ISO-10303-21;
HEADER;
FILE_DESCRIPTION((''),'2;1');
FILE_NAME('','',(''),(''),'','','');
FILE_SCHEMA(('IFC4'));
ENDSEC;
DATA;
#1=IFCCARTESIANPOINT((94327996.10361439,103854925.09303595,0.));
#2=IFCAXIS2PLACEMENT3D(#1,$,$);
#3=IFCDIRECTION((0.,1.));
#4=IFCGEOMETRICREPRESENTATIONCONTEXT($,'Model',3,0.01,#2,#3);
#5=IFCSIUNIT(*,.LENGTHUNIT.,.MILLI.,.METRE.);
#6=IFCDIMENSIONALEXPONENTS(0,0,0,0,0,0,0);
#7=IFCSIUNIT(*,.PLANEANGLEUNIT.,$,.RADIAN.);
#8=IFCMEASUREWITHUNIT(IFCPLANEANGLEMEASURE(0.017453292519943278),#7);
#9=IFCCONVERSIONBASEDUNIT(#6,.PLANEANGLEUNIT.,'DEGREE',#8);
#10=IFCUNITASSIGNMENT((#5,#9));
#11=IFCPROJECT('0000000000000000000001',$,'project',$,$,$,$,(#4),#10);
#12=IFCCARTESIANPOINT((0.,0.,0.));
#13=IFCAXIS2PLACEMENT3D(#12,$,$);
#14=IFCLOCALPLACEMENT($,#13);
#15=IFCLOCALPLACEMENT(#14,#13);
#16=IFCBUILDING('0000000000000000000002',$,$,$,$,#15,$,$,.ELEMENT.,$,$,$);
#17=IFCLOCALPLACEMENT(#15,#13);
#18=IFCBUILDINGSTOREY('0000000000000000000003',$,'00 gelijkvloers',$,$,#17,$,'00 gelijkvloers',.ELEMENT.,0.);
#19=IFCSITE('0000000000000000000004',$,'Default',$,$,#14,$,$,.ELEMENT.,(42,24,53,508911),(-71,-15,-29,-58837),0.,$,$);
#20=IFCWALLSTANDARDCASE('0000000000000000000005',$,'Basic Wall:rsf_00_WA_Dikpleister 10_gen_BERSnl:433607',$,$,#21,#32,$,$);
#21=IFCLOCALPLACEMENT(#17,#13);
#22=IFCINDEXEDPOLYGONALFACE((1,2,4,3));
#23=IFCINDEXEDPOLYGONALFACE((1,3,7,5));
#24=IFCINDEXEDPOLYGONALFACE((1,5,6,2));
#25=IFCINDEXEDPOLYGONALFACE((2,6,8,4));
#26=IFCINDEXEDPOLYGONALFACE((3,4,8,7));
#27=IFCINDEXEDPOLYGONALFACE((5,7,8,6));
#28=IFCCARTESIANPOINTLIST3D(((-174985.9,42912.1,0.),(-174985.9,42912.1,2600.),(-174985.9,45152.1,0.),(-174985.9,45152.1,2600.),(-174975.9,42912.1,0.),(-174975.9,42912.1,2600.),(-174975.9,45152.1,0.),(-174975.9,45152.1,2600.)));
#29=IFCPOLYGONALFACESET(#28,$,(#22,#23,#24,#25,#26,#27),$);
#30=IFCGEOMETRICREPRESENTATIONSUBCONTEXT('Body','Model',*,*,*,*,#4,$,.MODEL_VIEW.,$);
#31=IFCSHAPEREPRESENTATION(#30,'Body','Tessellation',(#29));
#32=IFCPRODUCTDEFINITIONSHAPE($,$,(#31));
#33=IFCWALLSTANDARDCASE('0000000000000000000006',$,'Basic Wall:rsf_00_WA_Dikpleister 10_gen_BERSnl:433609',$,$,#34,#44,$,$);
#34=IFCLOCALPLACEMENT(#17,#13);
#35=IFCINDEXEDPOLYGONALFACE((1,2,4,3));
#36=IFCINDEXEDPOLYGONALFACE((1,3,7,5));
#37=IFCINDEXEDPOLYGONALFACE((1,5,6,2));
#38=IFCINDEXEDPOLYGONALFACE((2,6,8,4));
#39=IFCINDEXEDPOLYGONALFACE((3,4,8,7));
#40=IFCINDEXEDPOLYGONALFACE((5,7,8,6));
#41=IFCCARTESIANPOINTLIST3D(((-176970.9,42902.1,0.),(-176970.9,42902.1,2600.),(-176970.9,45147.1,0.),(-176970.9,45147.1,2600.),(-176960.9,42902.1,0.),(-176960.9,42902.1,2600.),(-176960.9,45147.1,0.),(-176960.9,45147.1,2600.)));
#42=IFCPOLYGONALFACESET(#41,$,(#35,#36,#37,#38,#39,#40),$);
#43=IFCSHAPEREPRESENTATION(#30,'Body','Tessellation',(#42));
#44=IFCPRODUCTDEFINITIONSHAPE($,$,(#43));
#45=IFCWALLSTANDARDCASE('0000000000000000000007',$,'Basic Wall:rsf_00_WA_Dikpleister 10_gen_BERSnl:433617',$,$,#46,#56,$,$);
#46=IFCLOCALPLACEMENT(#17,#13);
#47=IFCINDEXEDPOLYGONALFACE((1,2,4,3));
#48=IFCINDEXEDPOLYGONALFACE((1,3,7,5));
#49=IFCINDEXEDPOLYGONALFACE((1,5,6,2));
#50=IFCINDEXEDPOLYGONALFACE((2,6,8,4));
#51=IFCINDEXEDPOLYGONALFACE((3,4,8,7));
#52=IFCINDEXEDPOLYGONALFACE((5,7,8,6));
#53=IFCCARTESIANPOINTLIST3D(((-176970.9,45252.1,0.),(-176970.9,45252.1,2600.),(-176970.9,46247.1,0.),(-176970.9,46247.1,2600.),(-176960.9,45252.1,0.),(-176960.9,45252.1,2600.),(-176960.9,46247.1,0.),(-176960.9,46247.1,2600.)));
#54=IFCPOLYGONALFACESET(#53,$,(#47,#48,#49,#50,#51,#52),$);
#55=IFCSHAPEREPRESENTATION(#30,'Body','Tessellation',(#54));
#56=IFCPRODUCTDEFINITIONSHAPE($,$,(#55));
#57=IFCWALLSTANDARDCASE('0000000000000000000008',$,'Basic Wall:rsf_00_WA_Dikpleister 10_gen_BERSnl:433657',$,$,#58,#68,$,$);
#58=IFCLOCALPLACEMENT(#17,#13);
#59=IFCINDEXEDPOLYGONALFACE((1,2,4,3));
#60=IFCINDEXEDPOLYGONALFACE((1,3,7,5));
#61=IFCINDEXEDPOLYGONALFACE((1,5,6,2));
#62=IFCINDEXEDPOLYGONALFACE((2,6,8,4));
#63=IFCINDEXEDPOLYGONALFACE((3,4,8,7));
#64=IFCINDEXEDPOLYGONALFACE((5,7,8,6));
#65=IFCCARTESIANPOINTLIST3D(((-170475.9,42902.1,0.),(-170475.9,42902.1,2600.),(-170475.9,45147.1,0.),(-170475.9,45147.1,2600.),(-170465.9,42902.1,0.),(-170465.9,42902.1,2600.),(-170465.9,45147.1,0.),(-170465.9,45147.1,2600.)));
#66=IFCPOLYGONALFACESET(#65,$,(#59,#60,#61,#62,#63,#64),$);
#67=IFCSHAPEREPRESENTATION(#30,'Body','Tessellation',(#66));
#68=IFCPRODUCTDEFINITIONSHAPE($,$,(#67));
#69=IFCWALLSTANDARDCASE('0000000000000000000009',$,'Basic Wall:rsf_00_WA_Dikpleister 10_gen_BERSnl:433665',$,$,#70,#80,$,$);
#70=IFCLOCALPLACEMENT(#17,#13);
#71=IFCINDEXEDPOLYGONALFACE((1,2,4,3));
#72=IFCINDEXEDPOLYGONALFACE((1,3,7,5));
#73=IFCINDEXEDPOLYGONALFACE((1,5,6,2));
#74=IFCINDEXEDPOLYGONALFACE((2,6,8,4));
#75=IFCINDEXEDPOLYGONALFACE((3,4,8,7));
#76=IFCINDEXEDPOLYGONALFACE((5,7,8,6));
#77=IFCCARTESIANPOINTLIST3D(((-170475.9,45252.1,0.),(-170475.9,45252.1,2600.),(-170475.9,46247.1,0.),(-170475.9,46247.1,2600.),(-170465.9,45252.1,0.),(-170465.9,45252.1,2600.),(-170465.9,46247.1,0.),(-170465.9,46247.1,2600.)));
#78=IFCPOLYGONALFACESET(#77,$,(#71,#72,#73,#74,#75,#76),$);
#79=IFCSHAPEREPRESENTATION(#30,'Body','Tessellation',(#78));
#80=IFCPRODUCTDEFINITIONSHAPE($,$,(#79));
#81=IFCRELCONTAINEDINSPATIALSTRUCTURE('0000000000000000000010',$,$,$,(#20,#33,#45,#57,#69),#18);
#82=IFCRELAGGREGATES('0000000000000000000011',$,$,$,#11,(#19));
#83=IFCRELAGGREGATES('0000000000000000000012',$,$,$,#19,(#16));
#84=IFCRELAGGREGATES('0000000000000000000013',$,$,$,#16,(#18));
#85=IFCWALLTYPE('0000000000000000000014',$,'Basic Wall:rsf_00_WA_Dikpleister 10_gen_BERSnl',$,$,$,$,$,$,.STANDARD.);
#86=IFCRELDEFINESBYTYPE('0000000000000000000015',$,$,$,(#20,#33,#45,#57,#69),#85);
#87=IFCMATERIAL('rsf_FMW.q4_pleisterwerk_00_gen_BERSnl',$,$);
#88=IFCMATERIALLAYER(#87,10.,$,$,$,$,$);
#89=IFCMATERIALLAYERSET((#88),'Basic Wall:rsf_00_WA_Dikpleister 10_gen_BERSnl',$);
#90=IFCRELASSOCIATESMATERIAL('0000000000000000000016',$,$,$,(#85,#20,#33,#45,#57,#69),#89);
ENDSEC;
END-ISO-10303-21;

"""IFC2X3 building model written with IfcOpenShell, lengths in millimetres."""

from ifc_helpers import new_model, entity, si_unit, converted_unit, direction, frame, frame_2d, origin, place, context, subcontext, project, spatial, rectangle, extrude, material, layer, layer_set, layer_usage, type_object, element, save


model = new_model("IFC2X3")

# Units and contexts
model_context = context("Model", 3, precision=0.01, world=frame((94327996.10361439, 103854925.09303595, 0.0)), true_north=direction((0.0, 1.0)))
body_context = subcontext(model_context, "Body", "Model", "MODEL_VIEW")
ifc_project = project(units=[si_unit("LENGTHUNIT", "METRE", prefix="MILLI"), converted_unit("PLANEANGLEUNIT", "DEGREE", entity("IfcPlaneAngleMeasure", 0.017453292519943278), si_unit("PLANEANGLEUNIT", "RADIAN"), dimensions=[0, 0, 0, 0, 0, 0, 0])], contexts=[model_context])

# Site, building, storey
site_placement = place(None, origin())
site = spatial("IfcSite", under=ifc_project, at=site_placement, Name="Default", CompositionType="ELEMENT", RefLatitude=(42, 24, 53, 508911), RefLongitude=(-71, -15, -29, -58837), RefElevation=0.0)
building_placement = place(site_placement, origin())
building = spatial("IfcBuilding", under=site, at=building_placement, CompositionType="ELEMENT")
storey_placement = place(building_placement, origin())
storey = spatial("IfcBuildingStorey", under=building, at=storey_placement, Name="00 gelijkvloers", LongName="00 gelijkvloers", CompositionType="ELEMENT", Elevation=0.0)

# Shared definitions
ifc_material_1 = material(Name="rsf_FMW.q4_pleisterwerk_00_gen_BERSnl")

# Walls
ifc_layer_1 = layer(ifc_material_1, 10.0)
ifc_layer_set_1 = layer_set([ifc_layer_1], Name="Basic Wall:rsf_00_WA_Dikpleister 10_gen_BERSnl")
wall_type_1 = type_object("IfcWallType", Name="Basic Wall:rsf_00_WA_Dikpleister 10_gen_BERSnl", PredefinedType="STANDARD", material=ifc_layer_set_1)
ifc_layer_usage_1 = layer_usage(ifc_layer_set_1, "AXIS2", "POSITIVE", -5.0)
wall_1_placement = place(storey_placement, frame((-174980.9, 45152.1, 0.0), z_axis=(0.0, 0.0, 1.0), x_axis=(0.0, -1.0, 0.0)))
element("IfcWallStandardCase", 1, at=wall_1_placement, inside=storey, type_object=wall_type_1, material=ifc_layer_usage_1, Name="Basic Wall:rsf_00_WA_Dikpleister 10_gen_BERSnl:433607", context=body_context, shape_type="SweptSolid", body=[
    extrude(rectangle(XDim=2240.0, YDim=10.0, at=frame_2d((1120.0, 0.0), x_axis=(-1.0, 0.0))), origin(), (0.0, 0.0, 1.0), 2600.0),
])
ifc_layer_usage_2 = layer_usage(ifc_layer_set_1, "AXIS2", "POSITIVE", -5.0)
wall_2_placement = place(storey_placement, frame((-176965.9, 42902.1, 0.0), z_axis=(0.0, 0.0, 1.0), x_axis=(0.0, 1.0, 0.0)))
element("IfcWallStandardCase", 2, at=wall_2_placement, inside=storey, type_object=wall_type_1, material=ifc_layer_usage_2, Name="Basic Wall:rsf_00_WA_Dikpleister 10_gen_BERSnl:433609", context=body_context, shape_type="SweptSolid", body=[
    extrude(rectangle(XDim=2245.0, YDim=10.0, at=frame_2d((1122.5, 0.0), x_axis=(-1.0, 0.0))), origin(), (0.0, 0.0, 1.0), 2600.0),
])
ifc_layer_usage_3 = layer_usage(ifc_layer_set_1, "AXIS2", "POSITIVE", -5.0)
wall_3_placement = place(storey_placement, frame((-176965.9, 45252.1, 0.0), z_axis=(0.0, 0.0, 1.0), x_axis=(0.0, 1.0, 0.0)))
element("IfcWallStandardCase", 3, at=wall_3_placement, inside=storey, type_object=wall_type_1, material=ifc_layer_usage_3, Name="Basic Wall:rsf_00_WA_Dikpleister 10_gen_BERSnl:433617", context=body_context, shape_type="SweptSolid", body=[
    extrude(rectangle(XDim=995.0, YDim=10.0, at=frame_2d((497.5, 0.0), x_axis=(-1.0, 0.0))), origin(), (0.0, 0.0, 1.0), 2600.0),
])
ifc_layer_usage_4 = layer_usage(ifc_layer_set_1, "AXIS2", "POSITIVE", -5.0)
wall_4_placement = place(storey_placement, frame((-170470.9, 42902.1, 0.0), z_axis=(0.0, 0.0, 1.0), x_axis=(0.0, 1.0, 0.0)))
element("IfcWallStandardCase", 4, at=wall_4_placement, inside=storey, type_object=wall_type_1, material=ifc_layer_usage_4, Name="Basic Wall:rsf_00_WA_Dikpleister 10_gen_BERSnl:433657", context=body_context, shape_type="SweptSolid", body=[
    extrude(rectangle(XDim=2245.0, YDim=10.0, at=frame_2d((1122.5, 0.0), x_axis=(-1.0, 0.0))), origin(), (0.0, 0.0, 1.0), 2600.0),
])
ifc_layer_usage_5 = layer_usage(ifc_layer_set_1, "AXIS2", "POSITIVE", -5.0)
wall_5_placement = place(storey_placement, frame((-170470.9, 45252.1, 0.0), z_axis=(0.0, 0.0, 1.0), x_axis=(0.0, 1.0, 0.0)))
element("IfcWallStandardCase", 5, at=wall_5_placement, inside=storey, type_object=wall_type_1, material=ifc_layer_usage_5, Name="Basic Wall:rsf_00_WA_Dikpleister 10_gen_BERSnl:433665", context=body_context, shape_type="SweptSolid", body=[
    extrude(rectangle(XDim=995.0, YDim=10.0, at=frame_2d((497.5, 0.0), x_axis=(-1.0, 0.0))), origin(), (0.0, 0.0, 1.0), 2600.0),
])

save(model, "model.ifc")
